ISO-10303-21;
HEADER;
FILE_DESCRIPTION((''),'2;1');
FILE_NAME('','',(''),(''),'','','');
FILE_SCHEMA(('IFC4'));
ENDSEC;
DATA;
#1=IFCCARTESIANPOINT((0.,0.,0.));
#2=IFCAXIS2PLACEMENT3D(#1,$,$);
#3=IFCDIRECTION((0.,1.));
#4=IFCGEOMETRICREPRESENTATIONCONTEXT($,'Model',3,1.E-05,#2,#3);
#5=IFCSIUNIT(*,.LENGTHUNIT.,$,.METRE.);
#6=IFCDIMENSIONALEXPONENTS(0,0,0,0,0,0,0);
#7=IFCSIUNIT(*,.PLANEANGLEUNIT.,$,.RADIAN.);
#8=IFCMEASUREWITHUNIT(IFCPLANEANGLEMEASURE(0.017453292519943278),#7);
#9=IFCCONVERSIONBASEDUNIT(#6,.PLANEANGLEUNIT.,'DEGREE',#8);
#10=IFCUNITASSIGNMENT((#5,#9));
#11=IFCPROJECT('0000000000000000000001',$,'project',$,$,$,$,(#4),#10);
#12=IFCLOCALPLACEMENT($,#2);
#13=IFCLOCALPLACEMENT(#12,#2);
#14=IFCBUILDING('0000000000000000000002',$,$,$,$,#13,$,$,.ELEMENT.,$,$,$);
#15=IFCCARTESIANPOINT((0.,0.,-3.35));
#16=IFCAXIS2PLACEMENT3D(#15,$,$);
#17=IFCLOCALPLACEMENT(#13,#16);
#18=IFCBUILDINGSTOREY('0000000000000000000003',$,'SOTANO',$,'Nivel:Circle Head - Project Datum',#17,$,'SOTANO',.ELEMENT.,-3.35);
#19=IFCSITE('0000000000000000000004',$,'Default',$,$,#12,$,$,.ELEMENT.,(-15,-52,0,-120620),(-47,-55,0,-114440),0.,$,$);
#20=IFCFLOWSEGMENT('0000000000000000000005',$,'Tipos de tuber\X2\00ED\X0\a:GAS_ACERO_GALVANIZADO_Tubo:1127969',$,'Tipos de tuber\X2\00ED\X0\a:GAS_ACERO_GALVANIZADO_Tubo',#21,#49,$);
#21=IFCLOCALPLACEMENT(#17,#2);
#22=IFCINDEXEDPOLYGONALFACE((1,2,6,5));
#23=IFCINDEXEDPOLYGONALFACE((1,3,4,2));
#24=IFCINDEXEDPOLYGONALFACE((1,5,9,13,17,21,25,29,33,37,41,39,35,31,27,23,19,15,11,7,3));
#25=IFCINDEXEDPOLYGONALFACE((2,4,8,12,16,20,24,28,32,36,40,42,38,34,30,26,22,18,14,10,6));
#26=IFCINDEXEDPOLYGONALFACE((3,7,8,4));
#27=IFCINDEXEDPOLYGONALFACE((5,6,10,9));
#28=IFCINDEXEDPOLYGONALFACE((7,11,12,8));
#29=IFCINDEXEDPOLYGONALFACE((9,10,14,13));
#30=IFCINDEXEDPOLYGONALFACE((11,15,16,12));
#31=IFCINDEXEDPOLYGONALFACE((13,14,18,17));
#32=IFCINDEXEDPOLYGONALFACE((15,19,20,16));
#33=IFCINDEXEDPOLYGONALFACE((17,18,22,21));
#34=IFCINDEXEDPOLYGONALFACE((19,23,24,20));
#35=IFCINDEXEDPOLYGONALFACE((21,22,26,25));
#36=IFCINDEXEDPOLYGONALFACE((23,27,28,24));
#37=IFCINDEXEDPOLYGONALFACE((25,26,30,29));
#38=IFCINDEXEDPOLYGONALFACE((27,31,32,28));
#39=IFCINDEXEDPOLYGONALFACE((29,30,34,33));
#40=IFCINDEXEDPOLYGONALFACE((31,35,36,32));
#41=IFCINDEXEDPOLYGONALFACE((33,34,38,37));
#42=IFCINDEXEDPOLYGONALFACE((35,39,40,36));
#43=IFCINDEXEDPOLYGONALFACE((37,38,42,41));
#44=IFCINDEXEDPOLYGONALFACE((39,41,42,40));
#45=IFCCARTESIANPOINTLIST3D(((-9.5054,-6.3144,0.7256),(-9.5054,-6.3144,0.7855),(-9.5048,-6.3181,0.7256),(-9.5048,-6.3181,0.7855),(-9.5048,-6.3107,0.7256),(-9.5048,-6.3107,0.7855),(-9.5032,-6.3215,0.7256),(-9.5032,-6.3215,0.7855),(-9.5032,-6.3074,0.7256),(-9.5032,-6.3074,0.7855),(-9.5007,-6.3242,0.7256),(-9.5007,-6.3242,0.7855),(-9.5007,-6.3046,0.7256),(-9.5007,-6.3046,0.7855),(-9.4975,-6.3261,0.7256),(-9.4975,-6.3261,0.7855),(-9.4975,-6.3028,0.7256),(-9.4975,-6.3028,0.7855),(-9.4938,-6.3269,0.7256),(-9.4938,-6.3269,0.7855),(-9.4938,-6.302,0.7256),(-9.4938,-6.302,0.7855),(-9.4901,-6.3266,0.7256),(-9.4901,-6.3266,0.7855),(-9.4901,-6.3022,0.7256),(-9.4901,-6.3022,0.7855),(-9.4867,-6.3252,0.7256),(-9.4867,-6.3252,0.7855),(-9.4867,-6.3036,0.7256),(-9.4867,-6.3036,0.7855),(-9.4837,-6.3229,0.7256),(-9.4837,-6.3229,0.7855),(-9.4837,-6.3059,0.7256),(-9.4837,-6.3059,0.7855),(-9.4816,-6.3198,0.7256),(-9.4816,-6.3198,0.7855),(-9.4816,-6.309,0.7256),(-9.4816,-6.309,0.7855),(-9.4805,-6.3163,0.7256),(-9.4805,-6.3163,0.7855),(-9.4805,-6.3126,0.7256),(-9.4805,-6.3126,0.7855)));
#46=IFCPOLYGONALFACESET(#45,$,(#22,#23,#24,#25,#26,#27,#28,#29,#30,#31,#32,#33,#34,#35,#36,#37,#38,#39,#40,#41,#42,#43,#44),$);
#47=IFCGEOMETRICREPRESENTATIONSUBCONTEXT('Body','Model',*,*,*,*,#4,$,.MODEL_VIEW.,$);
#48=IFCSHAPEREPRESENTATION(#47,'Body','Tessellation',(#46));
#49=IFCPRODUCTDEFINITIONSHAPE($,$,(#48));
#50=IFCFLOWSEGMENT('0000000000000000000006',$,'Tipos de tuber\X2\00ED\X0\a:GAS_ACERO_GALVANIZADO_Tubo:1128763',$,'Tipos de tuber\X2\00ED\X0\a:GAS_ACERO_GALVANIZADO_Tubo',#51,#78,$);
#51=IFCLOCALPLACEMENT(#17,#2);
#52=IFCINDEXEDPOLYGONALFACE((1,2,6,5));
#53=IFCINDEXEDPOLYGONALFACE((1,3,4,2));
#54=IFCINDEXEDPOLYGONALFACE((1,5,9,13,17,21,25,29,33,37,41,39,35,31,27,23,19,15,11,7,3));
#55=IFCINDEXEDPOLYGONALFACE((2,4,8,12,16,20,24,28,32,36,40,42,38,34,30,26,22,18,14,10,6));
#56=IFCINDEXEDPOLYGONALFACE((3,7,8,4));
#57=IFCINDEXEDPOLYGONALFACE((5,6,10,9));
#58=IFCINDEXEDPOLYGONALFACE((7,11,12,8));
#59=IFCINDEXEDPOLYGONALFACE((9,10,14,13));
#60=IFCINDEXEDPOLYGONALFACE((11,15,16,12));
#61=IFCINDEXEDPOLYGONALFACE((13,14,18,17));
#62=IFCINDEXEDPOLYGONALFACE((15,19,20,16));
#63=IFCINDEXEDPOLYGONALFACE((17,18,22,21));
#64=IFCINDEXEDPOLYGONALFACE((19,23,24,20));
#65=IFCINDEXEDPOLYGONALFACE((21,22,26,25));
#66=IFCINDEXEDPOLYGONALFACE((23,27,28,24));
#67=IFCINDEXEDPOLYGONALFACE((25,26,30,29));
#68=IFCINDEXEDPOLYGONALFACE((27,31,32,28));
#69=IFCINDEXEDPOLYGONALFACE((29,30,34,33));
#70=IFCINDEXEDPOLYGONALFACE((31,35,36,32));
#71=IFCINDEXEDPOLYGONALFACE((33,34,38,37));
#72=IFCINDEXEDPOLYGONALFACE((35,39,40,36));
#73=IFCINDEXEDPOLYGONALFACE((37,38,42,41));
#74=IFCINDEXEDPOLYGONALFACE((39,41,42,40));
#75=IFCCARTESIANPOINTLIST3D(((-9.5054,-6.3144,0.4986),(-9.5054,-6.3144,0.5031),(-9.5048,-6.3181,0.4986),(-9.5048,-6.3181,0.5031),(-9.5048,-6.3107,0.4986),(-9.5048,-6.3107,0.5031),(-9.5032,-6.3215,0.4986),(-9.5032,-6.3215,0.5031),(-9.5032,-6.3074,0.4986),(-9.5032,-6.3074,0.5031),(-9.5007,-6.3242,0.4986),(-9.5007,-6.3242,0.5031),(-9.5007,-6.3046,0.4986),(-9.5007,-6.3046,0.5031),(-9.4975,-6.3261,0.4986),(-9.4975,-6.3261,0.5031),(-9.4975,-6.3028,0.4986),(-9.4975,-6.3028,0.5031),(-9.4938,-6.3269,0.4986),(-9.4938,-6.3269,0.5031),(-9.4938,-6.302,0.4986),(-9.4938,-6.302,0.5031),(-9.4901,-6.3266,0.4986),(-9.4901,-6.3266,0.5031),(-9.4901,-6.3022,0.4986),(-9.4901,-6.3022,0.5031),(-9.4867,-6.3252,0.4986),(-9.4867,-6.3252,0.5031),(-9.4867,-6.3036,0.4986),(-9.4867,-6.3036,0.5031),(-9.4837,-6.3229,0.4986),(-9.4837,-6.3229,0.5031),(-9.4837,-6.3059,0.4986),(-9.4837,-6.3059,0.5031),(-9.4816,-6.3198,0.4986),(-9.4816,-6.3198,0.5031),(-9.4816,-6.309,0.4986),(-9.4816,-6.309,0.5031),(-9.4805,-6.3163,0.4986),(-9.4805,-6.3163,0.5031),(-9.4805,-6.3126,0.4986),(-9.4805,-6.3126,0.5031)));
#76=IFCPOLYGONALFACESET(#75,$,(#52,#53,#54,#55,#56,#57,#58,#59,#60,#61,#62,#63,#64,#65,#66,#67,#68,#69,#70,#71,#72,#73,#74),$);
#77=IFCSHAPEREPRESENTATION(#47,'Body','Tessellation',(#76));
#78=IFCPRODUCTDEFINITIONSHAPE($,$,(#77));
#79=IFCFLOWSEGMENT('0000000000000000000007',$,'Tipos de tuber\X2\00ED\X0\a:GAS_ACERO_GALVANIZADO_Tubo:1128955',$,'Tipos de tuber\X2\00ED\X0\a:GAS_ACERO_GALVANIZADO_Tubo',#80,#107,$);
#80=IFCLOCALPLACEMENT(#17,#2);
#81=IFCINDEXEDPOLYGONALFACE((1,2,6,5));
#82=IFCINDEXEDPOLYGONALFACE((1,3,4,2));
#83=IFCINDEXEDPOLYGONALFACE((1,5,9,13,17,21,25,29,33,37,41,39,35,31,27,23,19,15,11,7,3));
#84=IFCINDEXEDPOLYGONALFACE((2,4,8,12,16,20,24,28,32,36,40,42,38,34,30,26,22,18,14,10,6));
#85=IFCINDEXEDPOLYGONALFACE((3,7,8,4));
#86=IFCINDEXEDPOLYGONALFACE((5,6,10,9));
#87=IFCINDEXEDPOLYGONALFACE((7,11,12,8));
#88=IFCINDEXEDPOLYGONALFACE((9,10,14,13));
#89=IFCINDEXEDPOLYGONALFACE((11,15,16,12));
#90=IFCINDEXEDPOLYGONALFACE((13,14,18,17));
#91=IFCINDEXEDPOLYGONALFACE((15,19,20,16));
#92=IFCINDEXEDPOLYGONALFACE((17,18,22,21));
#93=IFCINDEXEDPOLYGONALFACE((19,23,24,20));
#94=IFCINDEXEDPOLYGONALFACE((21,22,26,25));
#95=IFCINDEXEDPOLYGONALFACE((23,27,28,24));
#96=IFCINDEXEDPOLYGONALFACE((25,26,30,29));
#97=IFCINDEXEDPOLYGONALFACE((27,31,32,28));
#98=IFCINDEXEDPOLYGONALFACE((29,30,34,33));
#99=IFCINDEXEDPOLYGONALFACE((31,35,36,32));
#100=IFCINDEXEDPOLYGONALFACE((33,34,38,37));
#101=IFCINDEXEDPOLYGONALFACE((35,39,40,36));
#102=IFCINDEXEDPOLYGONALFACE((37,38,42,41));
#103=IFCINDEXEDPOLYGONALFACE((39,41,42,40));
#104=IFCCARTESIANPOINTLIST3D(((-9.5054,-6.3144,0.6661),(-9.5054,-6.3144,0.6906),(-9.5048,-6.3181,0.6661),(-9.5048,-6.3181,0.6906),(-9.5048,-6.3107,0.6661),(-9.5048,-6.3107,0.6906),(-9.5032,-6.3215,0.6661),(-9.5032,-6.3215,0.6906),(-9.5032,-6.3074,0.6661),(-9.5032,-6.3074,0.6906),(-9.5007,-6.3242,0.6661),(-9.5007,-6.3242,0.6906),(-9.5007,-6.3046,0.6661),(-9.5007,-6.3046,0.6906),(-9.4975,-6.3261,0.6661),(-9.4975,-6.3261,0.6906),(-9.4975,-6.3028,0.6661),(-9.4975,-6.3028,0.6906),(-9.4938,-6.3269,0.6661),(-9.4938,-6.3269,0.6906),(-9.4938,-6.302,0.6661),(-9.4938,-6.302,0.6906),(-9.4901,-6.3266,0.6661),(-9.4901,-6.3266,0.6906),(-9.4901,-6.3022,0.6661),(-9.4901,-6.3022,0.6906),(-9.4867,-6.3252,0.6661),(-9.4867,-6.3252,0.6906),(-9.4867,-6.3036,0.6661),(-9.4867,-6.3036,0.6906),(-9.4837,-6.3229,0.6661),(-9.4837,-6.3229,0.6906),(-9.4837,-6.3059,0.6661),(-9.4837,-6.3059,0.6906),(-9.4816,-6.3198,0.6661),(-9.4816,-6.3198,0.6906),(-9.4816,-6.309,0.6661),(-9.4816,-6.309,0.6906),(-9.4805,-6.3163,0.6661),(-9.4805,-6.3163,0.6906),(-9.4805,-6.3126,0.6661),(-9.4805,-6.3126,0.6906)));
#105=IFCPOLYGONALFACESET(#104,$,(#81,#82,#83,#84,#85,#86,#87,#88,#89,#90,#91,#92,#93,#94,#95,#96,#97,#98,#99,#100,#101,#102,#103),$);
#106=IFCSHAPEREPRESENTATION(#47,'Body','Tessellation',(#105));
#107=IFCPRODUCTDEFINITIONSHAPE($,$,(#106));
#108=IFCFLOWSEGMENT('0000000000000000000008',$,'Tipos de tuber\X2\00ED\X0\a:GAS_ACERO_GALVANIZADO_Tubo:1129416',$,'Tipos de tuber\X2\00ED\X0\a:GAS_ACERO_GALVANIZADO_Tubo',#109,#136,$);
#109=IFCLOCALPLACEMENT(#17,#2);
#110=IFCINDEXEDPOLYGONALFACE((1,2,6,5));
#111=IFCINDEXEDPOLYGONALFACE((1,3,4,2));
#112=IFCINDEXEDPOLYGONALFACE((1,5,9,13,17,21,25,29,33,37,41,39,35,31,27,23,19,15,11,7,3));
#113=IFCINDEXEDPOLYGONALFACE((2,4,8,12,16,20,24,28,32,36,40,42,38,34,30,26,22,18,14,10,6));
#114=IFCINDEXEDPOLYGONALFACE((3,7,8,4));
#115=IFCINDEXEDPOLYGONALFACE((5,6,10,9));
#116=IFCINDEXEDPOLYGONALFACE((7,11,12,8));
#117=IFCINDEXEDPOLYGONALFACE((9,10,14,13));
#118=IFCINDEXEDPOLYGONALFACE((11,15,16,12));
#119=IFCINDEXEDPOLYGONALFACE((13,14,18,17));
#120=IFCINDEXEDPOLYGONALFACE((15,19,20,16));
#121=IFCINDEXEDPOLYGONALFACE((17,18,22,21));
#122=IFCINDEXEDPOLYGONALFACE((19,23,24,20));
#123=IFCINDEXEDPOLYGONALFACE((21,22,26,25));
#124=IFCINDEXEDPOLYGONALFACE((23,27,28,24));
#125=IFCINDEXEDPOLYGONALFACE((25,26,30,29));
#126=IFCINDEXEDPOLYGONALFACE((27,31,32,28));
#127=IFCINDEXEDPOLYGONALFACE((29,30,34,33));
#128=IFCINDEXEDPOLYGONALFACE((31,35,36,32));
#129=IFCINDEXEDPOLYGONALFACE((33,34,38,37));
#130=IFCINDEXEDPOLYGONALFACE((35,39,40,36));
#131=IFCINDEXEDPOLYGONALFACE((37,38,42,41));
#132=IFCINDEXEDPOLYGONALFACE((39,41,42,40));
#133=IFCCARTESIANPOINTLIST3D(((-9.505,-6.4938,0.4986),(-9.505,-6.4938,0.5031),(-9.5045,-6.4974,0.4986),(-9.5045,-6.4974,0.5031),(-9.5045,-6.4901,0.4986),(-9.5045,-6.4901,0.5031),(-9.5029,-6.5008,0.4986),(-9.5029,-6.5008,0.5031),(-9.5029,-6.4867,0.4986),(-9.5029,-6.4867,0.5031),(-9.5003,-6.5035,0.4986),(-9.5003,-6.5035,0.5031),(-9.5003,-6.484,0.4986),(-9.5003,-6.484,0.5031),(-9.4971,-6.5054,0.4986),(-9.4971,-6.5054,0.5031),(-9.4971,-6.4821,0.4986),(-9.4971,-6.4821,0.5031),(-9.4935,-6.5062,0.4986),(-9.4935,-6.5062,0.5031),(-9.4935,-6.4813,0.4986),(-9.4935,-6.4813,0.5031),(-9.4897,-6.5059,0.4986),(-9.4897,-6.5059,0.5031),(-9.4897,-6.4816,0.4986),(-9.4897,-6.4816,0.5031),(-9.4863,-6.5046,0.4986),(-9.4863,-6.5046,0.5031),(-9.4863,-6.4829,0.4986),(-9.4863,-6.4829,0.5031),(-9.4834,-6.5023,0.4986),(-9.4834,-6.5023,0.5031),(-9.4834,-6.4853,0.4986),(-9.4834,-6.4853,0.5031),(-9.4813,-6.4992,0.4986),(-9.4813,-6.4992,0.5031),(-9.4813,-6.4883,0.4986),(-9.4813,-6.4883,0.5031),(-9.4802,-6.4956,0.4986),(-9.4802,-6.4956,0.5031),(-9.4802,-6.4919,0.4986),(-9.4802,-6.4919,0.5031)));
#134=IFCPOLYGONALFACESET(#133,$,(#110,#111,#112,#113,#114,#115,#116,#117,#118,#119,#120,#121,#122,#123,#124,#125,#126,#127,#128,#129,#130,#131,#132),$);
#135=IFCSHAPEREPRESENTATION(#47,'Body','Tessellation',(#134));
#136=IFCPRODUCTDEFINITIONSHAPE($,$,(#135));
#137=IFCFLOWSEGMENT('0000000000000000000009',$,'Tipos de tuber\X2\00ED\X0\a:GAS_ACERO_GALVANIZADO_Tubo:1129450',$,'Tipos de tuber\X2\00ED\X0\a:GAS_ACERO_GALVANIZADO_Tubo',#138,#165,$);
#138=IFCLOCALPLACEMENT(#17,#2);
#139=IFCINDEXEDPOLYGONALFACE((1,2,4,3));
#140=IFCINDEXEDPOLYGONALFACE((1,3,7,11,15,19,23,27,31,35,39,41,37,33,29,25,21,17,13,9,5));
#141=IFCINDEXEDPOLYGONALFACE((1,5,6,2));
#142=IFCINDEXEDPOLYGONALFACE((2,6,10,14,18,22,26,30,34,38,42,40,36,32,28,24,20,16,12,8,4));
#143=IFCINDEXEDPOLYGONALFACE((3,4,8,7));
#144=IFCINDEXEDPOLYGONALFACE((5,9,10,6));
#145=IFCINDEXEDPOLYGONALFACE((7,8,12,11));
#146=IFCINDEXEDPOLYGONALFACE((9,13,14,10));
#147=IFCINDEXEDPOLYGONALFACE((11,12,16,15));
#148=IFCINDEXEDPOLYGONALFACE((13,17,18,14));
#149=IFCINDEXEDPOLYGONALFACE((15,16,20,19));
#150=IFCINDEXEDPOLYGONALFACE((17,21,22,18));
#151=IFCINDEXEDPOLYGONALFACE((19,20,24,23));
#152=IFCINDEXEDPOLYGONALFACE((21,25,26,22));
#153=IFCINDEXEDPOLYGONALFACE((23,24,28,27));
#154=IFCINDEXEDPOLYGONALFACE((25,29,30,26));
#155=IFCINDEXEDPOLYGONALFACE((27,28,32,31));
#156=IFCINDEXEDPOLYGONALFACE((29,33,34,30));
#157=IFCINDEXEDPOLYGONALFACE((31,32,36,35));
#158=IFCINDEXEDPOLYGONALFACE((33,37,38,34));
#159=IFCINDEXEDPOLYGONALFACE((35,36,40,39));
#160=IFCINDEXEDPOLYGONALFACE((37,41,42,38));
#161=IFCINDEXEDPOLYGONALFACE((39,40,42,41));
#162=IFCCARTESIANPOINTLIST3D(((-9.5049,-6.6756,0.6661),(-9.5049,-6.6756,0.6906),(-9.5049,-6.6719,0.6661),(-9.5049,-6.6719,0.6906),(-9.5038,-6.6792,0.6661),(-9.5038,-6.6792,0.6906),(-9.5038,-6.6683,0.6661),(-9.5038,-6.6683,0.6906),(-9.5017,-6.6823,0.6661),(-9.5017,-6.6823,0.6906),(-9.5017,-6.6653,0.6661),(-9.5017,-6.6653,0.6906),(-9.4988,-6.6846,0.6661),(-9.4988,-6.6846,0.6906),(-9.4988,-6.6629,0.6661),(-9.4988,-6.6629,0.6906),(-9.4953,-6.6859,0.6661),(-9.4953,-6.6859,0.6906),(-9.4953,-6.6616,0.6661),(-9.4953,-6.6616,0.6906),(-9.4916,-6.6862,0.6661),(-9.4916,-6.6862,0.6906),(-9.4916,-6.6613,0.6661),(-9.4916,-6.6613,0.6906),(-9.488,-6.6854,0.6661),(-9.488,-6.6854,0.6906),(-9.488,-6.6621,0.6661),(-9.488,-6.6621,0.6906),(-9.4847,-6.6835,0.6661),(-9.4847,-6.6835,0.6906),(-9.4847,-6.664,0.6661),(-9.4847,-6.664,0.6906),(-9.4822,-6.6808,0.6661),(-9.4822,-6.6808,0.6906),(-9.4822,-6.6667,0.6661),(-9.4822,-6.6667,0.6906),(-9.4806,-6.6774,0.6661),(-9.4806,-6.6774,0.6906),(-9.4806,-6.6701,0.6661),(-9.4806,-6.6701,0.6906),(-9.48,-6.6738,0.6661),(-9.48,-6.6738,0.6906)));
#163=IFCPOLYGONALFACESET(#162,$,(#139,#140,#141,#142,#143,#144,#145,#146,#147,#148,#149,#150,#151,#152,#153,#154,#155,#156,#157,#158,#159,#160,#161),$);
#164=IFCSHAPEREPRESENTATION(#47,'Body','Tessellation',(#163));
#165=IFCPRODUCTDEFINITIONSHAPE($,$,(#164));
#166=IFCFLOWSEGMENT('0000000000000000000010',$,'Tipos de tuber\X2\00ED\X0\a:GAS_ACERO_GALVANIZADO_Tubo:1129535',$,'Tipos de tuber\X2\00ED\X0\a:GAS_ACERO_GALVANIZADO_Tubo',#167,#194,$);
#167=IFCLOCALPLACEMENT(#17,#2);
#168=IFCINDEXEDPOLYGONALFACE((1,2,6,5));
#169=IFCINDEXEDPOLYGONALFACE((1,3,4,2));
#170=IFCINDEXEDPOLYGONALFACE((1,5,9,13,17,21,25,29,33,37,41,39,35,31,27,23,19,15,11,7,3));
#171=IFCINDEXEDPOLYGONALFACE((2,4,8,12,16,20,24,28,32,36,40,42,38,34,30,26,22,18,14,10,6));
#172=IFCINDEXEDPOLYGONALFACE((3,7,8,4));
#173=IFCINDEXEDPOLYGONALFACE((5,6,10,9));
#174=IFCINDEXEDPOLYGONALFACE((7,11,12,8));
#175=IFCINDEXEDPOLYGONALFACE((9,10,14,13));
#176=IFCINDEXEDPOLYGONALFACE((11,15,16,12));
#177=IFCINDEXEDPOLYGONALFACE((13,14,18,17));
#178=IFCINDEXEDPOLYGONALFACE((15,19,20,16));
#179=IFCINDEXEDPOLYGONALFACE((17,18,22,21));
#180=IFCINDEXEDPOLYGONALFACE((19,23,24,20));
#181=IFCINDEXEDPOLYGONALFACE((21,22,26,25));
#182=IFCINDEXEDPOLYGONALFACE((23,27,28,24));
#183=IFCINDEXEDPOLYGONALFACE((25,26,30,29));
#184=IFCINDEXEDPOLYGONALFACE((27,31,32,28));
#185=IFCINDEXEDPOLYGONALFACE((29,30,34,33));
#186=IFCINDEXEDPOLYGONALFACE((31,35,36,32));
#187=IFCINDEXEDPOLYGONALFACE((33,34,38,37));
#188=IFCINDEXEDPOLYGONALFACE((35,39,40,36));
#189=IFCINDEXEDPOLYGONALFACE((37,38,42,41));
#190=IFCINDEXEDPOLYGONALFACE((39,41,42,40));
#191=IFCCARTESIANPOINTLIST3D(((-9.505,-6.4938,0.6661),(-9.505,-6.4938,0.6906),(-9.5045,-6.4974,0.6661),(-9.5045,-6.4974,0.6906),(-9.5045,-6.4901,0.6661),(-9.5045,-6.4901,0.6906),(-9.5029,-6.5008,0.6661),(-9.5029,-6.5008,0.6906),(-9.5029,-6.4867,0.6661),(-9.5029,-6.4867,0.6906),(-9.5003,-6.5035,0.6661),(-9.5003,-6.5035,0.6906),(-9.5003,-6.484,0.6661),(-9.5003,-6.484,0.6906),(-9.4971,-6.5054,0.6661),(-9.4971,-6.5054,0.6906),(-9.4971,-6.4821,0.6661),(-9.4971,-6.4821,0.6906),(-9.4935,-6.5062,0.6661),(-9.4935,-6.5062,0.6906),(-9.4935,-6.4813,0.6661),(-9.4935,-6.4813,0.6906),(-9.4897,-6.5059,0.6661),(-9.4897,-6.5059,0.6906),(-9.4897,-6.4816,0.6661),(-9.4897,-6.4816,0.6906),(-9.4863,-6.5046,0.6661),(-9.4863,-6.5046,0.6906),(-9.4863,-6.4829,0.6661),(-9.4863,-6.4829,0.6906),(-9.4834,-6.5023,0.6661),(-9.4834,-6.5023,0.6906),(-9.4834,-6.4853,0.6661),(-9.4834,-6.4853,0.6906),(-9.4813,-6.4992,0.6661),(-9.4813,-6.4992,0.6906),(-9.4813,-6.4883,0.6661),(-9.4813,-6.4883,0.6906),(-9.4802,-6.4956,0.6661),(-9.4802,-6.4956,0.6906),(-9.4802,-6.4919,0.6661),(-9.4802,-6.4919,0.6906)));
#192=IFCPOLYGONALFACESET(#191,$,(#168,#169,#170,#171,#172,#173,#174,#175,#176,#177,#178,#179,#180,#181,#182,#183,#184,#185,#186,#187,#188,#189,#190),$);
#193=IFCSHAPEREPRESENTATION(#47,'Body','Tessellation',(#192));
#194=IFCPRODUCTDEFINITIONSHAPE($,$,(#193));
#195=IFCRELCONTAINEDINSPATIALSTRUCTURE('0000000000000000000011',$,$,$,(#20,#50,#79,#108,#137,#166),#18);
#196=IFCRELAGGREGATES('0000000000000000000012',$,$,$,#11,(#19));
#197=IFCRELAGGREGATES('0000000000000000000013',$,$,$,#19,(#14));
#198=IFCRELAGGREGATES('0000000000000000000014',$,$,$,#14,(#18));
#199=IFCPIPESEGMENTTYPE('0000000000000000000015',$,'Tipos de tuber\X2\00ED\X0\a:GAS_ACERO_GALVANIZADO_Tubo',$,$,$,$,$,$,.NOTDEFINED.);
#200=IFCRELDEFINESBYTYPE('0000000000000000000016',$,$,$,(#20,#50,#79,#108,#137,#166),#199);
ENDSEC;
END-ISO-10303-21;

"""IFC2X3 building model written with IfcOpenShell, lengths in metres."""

from ifc_helpers import new_model, entity, si_unit, converted_unit, direction, frame, frame_2d, origin, origin_2d_with_axis, place, context, subcontext, project, spatial, circle, extrude, type_object, element, save


model = new_model("IFC2X3")

# Units and contexts
model_context = context("Model", 3, precision=1e-05, world=origin(), true_north=direction((0.0, 1.0)))
body_context = subcontext(model_context, "Body", "Model", "MODEL_VIEW")
ifc_project = project(units=[si_unit("LENGTHUNIT", "METRE"), converted_unit("PLANEANGLEUNIT", "DEGREE", entity("IfcPlaneAngleMeasure", 0.017453292519943278), si_unit("PLANEANGLEUNIT", "RADIAN"), dimensions=[0, 0, 0, 0, 0, 0, 0])], contexts=[model_context])

# Site, building, storey
site_placement = place(None, origin())
site = spatial("IfcSite", under=ifc_project, at=site_placement, Name="Default", CompositionType="ELEMENT", RefLatitude=(-15, -52, 0, -120620), RefLongitude=(-47, -55, 0, -114440), RefElevation=0.0)
building_placement = place(site_placement, origin())
building = spatial("IfcBuilding", under=site, at=building_placement, CompositionType="ELEMENT")
storey_placement = place(building_placement, frame((0.0, 0.0, -3.35)))
storey = spatial("IfcBuildingStorey", under=building, at=storey_placement, Name="SOTANO", ObjectType="Nivel:Circle Head - Project Datum", LongName="SOTANO", CompositionType="ELEMENT", Elevation=-3.35)

# Flow segments
pipe_segment_type_1 = type_object("IfcPipeSegmentType", Name="Tipos de tubería:GAS_ACERO_GALVANIZADO_Tubo", PredefinedType="NOTDEFINED")
flow_segment_1_placement = place(storey_placement, origin())
element("IfcFlowSegment", 1, at=flow_segment_1_placement, inside=storey, type_object=pipe_segment_type_1, Name="Tipos de tubería:GAS_ACERO_GALVANIZADO_Tubo:1127969", ObjectType="Tipos de tubería:GAS_ACERO_GALVANIZADO_Tubo", context=body_context, shape_type="SweptSolid", body=[
    extrude(circle(Radius=0.0125, at=frame_2d((0.0, 0.0), x_axis=(1.0, 0.0))), frame((-9.4929, -6.3144, 0.7256), z_axis=(-0.000002, 0.0, 1.0), x_axis=(-1.0, 0.0, -0.000002)), (0.0, 0.0, 1.0), 0.0599),
])
flow_segment_2_placement = place(storey_placement, origin())
element("IfcFlowSegment", 2, at=flow_segment_2_placement, inside=storey, type_object=pipe_segment_type_1, Name="Tipos de tubería:GAS_ACERO_GALVANIZADO_Tubo:1128763", ObjectType="Tipos de tubería:GAS_ACERO_GALVANIZADO_Tubo", context=body_context, shape_type="SweptSolid", body=[
    extrude(circle(Radius=0.0125, at=origin_2d_with_axis()), frame((-9.4929, -6.3144, 0.4986), z_axis=(0.0, 0.0, 1.0), x_axis=(-1.0, 0.0, 0.0)), (0.0, 0.0, 1.0), 0.0045),
])
flow_segment_3_placement = place(storey_placement, origin())
element("IfcFlowSegment", 3, at=flow_segment_3_placement, inside=storey, type_object=pipe_segment_type_1, Name="Tipos de tubería:GAS_ACERO_GALVANIZADO_Tubo:1128955", ObjectType="Tipos de tubería:GAS_ACERO_GALVANIZADO_Tubo", context=body_context, shape_type="SweptSolid", body=[
    extrude(circle(Radius=0.0125, at=frame_2d((0.0, 0.0), x_axis=(1.0, 0.0))), frame((-9.4929, -6.3144, 0.6661), z_axis=(0.0, 0.0, 1.0), x_axis=(-1.0, 0.0, 0.0)), (0.0, 0.0, 1.0), 0.0245),
])
flow_segment_4_placement = place(storey_placement, origin())
element("IfcFlowSegment", 4, at=flow_segment_4_placement, inside=storey, type_object=pipe_segment_type_1, Name="Tipos de tubería:GAS_ACERO_GALVANIZADO_Tubo:1129416", ObjectType="Tipos de tubería:GAS_ACERO_GALVANIZADO_Tubo", context=body_context, shape_type="SweptSolid", body=[
    extrude(circle(Radius=0.0125, at=origin_2d_with_axis()), frame((-9.4925, -6.4938, 0.4986), z_axis=(0.0, 0.0, 1.0), x_axis=(-1.0, 0.0, 0.0)), (0.0, 0.0, 1.0), 0.0045),
])
flow_segment_5_placement = place(storey_placement, origin())
element("IfcFlowSegment", 5, at=flow_segment_5_placement, inside=storey, type_object=pipe_segment_type_1, Name="Tipos de tubería:GAS_ACERO_GALVANIZADO_Tubo:1129450", ObjectType="Tipos de tubería:GAS_ACERO_GALVANIZADO_Tubo", context=body_context, shape_type="SweptSolid", body=[
    extrude(circle(Radius=0.0125, at=origin_2d_with_axis()), frame((-9.4925, -6.6738, 0.6661)), (0.0, 0.0, 1.0), 0.0245),
])
flow_segment_6_placement = place(storey_placement, origin())
element("IfcFlowSegment", 6, at=flow_segment_6_placement, inside=storey, type_object=pipe_segment_type_1, Name="Tipos de tubería:GAS_ACERO_GALVANIZADO_Tubo:1129535", ObjectType="Tipos de tubería:GAS_ACERO_GALVANIZADO_Tubo", context=body_context, shape_type="SweptSolid", body=[
    extrude(circle(Radius=0.0125, at=origin_2d_with_axis()), frame((-9.4925, -6.4938, 0.6661), z_axis=(0.0, 0.0, 1.0), x_axis=(-1.0, 0.0, 0.0)), (0.0, 0.0, 1.0), 0.0245),
])

save(model, "model.ifc")
